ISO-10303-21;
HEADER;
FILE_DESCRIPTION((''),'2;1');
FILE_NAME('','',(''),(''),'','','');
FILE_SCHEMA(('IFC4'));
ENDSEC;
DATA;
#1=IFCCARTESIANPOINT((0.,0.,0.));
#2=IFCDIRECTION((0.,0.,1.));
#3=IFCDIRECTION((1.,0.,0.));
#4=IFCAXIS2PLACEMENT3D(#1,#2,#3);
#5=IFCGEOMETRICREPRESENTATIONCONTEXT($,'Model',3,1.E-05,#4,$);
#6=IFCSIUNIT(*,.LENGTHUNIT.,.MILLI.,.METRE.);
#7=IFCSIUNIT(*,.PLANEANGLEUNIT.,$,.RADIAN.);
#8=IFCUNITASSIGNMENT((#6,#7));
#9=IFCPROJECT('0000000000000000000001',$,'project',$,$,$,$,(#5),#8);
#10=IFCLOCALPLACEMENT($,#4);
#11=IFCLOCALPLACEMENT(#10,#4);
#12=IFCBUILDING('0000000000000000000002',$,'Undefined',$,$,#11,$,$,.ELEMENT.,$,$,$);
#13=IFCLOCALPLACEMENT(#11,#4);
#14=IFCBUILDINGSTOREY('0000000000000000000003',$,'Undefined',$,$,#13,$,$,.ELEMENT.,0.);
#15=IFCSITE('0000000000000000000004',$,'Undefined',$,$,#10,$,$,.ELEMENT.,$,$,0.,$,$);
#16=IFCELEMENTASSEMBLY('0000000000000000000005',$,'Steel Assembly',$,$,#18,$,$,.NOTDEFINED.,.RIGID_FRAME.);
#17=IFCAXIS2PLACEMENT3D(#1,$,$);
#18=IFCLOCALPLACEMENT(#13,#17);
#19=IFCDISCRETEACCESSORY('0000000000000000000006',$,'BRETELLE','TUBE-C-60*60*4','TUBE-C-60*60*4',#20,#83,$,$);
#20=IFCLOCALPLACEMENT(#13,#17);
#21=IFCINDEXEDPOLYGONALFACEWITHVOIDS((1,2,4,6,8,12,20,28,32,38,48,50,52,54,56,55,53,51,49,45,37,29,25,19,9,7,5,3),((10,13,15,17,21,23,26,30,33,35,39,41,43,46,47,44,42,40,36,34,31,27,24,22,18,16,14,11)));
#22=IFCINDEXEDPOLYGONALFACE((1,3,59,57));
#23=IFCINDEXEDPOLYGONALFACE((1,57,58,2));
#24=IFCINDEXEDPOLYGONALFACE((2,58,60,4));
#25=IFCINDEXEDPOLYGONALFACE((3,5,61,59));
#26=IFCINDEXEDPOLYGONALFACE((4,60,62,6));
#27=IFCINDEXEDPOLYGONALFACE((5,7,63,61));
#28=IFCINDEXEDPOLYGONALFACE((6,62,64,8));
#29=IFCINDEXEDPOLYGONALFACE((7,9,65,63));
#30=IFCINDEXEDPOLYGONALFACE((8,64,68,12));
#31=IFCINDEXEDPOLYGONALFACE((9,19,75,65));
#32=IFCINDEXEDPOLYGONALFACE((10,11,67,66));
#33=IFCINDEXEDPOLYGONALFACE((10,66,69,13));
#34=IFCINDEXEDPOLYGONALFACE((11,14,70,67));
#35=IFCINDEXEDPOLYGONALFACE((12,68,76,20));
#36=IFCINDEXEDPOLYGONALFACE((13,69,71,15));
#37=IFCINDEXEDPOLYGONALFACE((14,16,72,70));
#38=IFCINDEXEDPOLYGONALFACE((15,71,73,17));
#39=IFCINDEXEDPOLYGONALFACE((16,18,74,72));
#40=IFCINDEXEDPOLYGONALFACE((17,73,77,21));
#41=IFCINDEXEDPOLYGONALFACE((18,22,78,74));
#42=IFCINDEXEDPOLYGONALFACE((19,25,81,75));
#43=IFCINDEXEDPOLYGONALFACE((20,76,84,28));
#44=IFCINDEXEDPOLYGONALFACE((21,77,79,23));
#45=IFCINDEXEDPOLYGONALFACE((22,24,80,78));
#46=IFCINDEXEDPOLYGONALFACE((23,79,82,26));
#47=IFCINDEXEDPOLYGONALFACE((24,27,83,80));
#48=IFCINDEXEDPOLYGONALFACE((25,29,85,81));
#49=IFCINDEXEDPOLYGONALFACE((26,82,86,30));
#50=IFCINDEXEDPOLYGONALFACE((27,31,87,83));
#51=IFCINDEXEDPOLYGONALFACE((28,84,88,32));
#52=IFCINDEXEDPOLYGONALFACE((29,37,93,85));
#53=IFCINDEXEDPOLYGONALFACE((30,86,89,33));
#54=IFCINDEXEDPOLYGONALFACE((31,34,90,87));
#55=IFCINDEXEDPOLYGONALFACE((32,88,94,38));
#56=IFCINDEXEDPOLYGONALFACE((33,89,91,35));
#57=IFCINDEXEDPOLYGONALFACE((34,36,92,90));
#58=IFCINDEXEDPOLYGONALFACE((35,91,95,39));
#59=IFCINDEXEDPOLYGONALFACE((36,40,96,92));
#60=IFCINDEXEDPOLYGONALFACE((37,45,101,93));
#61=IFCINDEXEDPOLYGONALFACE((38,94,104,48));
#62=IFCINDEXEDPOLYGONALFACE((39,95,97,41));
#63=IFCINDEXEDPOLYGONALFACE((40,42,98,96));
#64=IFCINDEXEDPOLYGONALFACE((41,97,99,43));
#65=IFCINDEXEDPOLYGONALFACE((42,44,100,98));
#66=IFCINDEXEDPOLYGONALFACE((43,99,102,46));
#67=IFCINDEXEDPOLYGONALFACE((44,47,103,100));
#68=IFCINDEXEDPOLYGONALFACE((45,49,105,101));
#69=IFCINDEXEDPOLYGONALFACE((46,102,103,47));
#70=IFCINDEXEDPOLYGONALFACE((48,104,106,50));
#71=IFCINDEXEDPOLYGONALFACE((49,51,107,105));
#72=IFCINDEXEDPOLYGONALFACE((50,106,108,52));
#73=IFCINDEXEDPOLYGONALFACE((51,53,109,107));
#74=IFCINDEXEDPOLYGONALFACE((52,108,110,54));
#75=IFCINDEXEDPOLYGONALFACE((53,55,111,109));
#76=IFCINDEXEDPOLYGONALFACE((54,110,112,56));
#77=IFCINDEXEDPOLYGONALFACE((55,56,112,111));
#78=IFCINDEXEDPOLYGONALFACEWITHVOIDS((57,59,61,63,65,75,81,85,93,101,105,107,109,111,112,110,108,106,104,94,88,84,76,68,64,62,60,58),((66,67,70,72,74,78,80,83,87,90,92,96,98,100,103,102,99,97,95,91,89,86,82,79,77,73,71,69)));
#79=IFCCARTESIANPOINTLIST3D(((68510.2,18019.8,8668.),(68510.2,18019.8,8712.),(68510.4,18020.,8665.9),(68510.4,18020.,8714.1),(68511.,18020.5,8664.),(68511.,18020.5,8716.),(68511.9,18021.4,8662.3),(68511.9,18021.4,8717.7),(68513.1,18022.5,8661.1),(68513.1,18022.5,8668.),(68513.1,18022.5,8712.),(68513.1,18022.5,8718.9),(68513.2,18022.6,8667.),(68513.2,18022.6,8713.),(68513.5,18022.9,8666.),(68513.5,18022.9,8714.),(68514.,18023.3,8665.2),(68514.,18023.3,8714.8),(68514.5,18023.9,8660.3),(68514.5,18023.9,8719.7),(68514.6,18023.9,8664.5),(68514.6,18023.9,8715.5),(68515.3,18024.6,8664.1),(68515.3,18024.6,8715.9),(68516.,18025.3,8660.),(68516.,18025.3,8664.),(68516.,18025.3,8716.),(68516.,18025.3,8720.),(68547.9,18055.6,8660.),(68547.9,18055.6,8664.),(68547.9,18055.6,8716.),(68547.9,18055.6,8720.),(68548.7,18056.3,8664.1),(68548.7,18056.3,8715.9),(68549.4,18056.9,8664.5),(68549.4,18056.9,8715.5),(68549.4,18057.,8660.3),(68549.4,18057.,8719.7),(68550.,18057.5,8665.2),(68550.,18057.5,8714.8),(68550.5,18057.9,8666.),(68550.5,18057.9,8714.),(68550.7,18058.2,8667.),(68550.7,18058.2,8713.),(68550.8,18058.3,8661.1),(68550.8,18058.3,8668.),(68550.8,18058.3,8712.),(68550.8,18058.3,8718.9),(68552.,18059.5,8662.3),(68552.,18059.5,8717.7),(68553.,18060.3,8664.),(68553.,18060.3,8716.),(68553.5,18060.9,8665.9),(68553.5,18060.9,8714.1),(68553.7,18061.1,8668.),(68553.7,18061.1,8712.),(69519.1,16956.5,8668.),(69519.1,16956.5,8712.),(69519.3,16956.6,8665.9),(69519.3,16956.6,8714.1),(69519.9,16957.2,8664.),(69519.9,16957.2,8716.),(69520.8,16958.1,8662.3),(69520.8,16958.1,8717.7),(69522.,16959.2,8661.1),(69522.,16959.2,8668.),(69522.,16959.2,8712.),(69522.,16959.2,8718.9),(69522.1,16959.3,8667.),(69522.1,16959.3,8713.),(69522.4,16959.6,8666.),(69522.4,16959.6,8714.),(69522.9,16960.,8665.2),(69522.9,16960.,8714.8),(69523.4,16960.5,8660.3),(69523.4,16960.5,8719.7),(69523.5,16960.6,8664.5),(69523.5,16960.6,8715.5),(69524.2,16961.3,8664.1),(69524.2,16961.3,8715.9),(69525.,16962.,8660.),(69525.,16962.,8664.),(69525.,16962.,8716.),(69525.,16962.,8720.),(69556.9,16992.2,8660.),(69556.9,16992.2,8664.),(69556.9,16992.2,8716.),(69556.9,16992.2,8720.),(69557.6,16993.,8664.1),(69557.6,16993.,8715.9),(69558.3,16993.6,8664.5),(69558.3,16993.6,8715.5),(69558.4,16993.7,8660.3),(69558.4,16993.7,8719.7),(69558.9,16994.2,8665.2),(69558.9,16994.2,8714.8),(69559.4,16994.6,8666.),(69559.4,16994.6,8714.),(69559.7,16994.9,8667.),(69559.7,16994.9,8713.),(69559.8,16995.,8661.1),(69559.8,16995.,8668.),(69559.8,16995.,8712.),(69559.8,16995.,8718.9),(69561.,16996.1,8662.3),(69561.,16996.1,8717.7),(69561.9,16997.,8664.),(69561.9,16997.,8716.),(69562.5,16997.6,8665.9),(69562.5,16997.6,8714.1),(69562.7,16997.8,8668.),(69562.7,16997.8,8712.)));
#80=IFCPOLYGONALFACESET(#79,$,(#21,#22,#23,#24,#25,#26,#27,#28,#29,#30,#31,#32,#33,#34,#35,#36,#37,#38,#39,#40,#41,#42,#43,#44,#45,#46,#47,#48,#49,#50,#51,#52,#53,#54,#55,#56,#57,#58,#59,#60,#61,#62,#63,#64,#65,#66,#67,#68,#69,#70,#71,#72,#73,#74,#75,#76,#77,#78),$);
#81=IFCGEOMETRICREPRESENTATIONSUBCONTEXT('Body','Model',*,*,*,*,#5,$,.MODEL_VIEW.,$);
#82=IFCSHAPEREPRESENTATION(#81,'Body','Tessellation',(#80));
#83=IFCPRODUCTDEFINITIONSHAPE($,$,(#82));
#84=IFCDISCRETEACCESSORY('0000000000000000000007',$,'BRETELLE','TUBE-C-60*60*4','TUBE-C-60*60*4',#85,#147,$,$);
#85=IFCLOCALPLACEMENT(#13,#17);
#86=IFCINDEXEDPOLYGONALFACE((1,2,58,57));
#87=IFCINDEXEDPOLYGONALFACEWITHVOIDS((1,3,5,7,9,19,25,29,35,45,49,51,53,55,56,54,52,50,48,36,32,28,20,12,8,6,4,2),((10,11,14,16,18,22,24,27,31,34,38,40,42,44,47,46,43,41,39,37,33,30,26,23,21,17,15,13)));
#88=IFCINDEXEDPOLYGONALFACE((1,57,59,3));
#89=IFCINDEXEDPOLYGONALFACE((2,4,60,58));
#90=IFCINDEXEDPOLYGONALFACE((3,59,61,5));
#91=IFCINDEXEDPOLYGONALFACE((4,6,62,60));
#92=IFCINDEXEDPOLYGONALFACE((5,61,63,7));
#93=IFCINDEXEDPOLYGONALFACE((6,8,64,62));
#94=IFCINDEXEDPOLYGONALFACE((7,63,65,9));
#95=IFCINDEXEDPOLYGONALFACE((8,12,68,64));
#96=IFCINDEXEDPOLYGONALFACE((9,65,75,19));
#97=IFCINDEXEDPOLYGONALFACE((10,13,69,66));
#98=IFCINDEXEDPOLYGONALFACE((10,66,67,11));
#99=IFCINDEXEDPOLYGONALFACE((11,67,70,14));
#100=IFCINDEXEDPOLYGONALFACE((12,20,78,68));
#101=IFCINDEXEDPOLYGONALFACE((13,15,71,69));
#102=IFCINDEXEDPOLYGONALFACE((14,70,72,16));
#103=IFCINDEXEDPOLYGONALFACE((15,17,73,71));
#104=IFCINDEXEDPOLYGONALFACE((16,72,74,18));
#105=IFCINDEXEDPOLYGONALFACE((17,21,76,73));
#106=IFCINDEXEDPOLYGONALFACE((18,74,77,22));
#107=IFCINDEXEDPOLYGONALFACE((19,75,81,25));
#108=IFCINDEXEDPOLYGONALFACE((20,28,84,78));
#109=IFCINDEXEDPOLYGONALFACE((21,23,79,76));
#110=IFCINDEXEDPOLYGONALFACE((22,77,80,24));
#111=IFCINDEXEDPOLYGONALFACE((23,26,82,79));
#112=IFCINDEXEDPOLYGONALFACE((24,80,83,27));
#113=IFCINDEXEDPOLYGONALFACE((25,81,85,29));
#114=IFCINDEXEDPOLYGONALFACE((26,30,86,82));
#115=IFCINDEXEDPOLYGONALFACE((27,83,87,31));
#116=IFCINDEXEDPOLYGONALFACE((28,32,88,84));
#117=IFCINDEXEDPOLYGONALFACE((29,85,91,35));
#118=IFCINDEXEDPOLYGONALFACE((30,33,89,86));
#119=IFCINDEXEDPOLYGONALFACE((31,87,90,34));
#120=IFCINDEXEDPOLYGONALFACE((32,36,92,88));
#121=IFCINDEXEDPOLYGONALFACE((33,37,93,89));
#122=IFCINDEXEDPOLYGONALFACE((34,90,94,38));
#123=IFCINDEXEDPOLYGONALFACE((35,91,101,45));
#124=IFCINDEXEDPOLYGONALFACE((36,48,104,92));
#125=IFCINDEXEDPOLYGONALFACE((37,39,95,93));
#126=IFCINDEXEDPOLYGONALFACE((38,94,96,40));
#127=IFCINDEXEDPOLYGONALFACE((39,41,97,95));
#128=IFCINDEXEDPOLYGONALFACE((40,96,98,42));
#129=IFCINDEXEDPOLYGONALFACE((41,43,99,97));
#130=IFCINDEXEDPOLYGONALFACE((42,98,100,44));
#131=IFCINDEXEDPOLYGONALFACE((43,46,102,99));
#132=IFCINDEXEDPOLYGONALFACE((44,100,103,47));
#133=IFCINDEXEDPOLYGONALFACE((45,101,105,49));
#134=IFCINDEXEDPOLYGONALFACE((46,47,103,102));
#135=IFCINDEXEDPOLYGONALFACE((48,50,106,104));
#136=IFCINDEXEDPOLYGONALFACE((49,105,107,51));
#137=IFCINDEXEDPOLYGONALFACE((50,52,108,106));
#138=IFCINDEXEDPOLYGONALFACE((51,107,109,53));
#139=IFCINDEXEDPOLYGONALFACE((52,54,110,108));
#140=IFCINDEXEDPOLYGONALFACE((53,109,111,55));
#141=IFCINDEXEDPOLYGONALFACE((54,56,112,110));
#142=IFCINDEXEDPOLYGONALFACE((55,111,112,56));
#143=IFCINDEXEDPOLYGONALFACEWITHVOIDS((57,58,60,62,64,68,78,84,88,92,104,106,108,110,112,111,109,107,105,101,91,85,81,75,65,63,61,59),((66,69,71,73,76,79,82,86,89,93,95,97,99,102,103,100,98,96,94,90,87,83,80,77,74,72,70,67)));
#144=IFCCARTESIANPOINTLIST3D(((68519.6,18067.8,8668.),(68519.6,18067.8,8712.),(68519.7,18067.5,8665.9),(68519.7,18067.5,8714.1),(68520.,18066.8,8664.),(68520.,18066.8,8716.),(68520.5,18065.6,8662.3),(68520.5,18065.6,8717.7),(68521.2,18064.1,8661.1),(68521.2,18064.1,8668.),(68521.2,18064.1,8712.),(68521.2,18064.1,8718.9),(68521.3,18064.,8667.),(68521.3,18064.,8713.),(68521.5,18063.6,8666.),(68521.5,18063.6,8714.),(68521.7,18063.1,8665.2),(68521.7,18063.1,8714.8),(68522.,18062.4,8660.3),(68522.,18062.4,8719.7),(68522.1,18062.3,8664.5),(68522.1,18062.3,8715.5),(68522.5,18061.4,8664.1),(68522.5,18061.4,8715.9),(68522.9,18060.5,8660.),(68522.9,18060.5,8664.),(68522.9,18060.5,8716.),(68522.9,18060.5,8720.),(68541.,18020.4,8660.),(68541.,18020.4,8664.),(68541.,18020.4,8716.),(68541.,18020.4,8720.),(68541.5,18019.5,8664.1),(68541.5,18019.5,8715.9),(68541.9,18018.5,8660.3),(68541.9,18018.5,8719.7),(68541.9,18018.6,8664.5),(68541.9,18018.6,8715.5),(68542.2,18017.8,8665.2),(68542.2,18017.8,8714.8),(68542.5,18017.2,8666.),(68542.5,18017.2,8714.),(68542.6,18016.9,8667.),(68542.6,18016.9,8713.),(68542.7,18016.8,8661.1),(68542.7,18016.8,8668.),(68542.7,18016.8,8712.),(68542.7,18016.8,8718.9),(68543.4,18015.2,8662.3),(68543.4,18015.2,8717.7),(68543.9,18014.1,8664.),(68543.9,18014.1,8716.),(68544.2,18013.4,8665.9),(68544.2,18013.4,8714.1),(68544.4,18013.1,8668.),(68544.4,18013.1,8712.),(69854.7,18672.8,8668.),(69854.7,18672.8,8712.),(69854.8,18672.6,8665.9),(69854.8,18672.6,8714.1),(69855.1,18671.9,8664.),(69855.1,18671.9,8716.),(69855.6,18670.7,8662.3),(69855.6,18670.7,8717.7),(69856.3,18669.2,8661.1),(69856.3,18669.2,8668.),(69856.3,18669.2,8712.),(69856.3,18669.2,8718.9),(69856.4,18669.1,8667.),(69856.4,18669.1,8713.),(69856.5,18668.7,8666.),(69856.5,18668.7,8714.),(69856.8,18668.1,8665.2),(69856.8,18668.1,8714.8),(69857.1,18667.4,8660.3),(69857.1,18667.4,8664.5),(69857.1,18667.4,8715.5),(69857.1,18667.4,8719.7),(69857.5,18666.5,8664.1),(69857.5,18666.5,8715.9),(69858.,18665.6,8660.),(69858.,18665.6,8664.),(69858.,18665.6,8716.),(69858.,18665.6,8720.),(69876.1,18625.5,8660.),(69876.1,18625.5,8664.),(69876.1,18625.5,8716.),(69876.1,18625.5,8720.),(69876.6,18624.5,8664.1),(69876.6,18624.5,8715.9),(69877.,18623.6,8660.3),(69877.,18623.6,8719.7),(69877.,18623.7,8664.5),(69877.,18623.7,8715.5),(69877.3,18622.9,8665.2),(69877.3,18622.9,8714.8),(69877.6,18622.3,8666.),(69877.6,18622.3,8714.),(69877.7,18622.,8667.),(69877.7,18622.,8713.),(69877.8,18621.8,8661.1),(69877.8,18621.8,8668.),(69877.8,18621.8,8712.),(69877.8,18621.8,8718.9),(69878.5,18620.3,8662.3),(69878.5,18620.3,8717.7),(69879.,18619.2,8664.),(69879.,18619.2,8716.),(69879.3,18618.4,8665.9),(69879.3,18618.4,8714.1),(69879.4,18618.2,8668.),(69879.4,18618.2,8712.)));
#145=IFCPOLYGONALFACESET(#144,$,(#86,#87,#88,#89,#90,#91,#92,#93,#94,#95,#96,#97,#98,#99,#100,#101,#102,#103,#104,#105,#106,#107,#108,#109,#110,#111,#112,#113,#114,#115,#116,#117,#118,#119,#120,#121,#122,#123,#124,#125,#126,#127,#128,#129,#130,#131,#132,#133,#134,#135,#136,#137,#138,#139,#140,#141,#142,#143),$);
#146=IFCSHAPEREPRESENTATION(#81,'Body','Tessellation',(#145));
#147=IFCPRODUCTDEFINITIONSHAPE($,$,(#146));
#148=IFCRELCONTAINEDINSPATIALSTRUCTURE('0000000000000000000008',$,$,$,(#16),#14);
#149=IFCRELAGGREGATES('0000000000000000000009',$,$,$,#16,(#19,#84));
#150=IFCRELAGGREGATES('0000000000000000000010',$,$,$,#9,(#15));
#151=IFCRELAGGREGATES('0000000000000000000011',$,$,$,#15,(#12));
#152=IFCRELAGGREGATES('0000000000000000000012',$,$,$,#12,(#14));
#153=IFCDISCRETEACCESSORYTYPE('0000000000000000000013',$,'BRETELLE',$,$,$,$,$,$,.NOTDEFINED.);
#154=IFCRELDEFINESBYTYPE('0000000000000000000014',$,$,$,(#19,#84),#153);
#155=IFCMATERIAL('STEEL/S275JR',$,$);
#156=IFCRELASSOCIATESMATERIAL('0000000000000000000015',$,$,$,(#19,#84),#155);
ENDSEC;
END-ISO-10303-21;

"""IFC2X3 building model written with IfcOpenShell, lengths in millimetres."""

from ifc_helpers import new_model, si_unit, frame, origin_with_axes, origin_2d_with_axis, place, context, subcontext, project, spatial, hollow_rectangle, extrude, material, type_object, element, aggregate, save


model = new_model("IFC2X3")

# Units and contexts
model_context = context("Model", 3, precision=1e-05, world=origin_with_axes())
body_context = subcontext(model_context, "Body", "Model", "MODEL_VIEW")
ifc_project = project(units=[si_unit("LENGTHUNIT", "METRE", prefix="MILLI"), si_unit("PLANEANGLEUNIT", "RADIAN")], contexts=[model_context])

# Site, building, storey
site_placement = place(None, origin_with_axes())
site = spatial("IfcSite", under=ifc_project, at=site_placement, Name="Undefined", CompositionType="ELEMENT", RefElevation=0.0)
building_placement = place(site_placement, origin_with_axes())
building = spatial("IfcBuilding", under=site, at=building_placement, Name="Undefined", CompositionType="ELEMENT")
storey_placement = place(building_placement, origin_with_axes())
storey = spatial("IfcBuildingStorey", under=building, at=storey_placement, Name="Undefined", CompositionType="ELEMENT", Elevation=0.0)

# Shared definitions
ifc_material = material(Name="STEEL/S275JR")

# Element assembly, discrete accessories
assembly_1_placement = place(storey_placement, origin_with_axes())
assembly_1 = element("IfcElementAssembly", 1, at=assembly_1_placement, inside=storey, Name="Steel Assembly", AssemblyPlace="NOTDEFINED", PredefinedType="RIGID_FRAME")
discrete_accessory_type_1 = type_object("IfcDiscreteAccessoryType", Name="BRETELLE")
discrete_accessory_1_placement = place(assembly_1_placement, frame((68532.0, 18040.4, 8690.0), z_axis=(0.725415, 0.688312, 0.0), x_axis=(0.688312, -0.725415, 0.0)))
discrete_accessory_1 = element("IfcDiscreteAccessory", 2, at=discrete_accessory_1_placement, type_object=discrete_accessory_type_1, material=ifc_material, Name="BRETELLE", Description="TUBE-C-60*60*4", ObjectType="TUBE-C-60*60*4", context=body_context, shape_type="SweptSolid", body=[
    extrude(hollow_rectangle(XDim=60.0, YDim=60.0, WallThickness=4.0, InnerFilletRadius=4.0, OuterFilletRadius=8.0, at=origin_2d_with_axis()), frame((1465.8, 0.0, 0.0), z_axis=(-1.0, 0.0, 0.0), x_axis=(0.0, -1.0, 0.0)), (0.0, 0.0, 1.0), 1465.8),
])
discrete_accessory_2_placement = place(assembly_1_placement, frame((69867.1, 18645.5, 8690.0), z_axis=(-0.412798, 0.910823, 0.0), x_axis=(-0.910823, -0.412798, 0.0)))
discrete_accessory_2 = element("IfcDiscreteAccessory", 3, at=discrete_accessory_2_placement, type_object=discrete_accessory_type_1, material=ifc_material, Name="BRETELLE", Description="TUBE-C-60*60*4", ObjectType="TUBE-C-60*60*4", context=body_context, shape_type="SweptSolid", body=[
    extrude(hollow_rectangle(XDim=60.0, YDim=60.0, WallThickness=4.0, InnerFilletRadius=4.0, OuterFilletRadius=8.0, at=origin_2d_with_axis()), frame((1465.8, 0.0, 0.0), z_axis=(-1.0, 0.0, 0.0), x_axis=(0.0, -1.0, 0.0)), (0.0, 0.0, 1.0), 1465.8),
])
aggregate(assembly_1, [discrete_accessory_1, discrete_accessory_2])

save(model, "model.ifc")
